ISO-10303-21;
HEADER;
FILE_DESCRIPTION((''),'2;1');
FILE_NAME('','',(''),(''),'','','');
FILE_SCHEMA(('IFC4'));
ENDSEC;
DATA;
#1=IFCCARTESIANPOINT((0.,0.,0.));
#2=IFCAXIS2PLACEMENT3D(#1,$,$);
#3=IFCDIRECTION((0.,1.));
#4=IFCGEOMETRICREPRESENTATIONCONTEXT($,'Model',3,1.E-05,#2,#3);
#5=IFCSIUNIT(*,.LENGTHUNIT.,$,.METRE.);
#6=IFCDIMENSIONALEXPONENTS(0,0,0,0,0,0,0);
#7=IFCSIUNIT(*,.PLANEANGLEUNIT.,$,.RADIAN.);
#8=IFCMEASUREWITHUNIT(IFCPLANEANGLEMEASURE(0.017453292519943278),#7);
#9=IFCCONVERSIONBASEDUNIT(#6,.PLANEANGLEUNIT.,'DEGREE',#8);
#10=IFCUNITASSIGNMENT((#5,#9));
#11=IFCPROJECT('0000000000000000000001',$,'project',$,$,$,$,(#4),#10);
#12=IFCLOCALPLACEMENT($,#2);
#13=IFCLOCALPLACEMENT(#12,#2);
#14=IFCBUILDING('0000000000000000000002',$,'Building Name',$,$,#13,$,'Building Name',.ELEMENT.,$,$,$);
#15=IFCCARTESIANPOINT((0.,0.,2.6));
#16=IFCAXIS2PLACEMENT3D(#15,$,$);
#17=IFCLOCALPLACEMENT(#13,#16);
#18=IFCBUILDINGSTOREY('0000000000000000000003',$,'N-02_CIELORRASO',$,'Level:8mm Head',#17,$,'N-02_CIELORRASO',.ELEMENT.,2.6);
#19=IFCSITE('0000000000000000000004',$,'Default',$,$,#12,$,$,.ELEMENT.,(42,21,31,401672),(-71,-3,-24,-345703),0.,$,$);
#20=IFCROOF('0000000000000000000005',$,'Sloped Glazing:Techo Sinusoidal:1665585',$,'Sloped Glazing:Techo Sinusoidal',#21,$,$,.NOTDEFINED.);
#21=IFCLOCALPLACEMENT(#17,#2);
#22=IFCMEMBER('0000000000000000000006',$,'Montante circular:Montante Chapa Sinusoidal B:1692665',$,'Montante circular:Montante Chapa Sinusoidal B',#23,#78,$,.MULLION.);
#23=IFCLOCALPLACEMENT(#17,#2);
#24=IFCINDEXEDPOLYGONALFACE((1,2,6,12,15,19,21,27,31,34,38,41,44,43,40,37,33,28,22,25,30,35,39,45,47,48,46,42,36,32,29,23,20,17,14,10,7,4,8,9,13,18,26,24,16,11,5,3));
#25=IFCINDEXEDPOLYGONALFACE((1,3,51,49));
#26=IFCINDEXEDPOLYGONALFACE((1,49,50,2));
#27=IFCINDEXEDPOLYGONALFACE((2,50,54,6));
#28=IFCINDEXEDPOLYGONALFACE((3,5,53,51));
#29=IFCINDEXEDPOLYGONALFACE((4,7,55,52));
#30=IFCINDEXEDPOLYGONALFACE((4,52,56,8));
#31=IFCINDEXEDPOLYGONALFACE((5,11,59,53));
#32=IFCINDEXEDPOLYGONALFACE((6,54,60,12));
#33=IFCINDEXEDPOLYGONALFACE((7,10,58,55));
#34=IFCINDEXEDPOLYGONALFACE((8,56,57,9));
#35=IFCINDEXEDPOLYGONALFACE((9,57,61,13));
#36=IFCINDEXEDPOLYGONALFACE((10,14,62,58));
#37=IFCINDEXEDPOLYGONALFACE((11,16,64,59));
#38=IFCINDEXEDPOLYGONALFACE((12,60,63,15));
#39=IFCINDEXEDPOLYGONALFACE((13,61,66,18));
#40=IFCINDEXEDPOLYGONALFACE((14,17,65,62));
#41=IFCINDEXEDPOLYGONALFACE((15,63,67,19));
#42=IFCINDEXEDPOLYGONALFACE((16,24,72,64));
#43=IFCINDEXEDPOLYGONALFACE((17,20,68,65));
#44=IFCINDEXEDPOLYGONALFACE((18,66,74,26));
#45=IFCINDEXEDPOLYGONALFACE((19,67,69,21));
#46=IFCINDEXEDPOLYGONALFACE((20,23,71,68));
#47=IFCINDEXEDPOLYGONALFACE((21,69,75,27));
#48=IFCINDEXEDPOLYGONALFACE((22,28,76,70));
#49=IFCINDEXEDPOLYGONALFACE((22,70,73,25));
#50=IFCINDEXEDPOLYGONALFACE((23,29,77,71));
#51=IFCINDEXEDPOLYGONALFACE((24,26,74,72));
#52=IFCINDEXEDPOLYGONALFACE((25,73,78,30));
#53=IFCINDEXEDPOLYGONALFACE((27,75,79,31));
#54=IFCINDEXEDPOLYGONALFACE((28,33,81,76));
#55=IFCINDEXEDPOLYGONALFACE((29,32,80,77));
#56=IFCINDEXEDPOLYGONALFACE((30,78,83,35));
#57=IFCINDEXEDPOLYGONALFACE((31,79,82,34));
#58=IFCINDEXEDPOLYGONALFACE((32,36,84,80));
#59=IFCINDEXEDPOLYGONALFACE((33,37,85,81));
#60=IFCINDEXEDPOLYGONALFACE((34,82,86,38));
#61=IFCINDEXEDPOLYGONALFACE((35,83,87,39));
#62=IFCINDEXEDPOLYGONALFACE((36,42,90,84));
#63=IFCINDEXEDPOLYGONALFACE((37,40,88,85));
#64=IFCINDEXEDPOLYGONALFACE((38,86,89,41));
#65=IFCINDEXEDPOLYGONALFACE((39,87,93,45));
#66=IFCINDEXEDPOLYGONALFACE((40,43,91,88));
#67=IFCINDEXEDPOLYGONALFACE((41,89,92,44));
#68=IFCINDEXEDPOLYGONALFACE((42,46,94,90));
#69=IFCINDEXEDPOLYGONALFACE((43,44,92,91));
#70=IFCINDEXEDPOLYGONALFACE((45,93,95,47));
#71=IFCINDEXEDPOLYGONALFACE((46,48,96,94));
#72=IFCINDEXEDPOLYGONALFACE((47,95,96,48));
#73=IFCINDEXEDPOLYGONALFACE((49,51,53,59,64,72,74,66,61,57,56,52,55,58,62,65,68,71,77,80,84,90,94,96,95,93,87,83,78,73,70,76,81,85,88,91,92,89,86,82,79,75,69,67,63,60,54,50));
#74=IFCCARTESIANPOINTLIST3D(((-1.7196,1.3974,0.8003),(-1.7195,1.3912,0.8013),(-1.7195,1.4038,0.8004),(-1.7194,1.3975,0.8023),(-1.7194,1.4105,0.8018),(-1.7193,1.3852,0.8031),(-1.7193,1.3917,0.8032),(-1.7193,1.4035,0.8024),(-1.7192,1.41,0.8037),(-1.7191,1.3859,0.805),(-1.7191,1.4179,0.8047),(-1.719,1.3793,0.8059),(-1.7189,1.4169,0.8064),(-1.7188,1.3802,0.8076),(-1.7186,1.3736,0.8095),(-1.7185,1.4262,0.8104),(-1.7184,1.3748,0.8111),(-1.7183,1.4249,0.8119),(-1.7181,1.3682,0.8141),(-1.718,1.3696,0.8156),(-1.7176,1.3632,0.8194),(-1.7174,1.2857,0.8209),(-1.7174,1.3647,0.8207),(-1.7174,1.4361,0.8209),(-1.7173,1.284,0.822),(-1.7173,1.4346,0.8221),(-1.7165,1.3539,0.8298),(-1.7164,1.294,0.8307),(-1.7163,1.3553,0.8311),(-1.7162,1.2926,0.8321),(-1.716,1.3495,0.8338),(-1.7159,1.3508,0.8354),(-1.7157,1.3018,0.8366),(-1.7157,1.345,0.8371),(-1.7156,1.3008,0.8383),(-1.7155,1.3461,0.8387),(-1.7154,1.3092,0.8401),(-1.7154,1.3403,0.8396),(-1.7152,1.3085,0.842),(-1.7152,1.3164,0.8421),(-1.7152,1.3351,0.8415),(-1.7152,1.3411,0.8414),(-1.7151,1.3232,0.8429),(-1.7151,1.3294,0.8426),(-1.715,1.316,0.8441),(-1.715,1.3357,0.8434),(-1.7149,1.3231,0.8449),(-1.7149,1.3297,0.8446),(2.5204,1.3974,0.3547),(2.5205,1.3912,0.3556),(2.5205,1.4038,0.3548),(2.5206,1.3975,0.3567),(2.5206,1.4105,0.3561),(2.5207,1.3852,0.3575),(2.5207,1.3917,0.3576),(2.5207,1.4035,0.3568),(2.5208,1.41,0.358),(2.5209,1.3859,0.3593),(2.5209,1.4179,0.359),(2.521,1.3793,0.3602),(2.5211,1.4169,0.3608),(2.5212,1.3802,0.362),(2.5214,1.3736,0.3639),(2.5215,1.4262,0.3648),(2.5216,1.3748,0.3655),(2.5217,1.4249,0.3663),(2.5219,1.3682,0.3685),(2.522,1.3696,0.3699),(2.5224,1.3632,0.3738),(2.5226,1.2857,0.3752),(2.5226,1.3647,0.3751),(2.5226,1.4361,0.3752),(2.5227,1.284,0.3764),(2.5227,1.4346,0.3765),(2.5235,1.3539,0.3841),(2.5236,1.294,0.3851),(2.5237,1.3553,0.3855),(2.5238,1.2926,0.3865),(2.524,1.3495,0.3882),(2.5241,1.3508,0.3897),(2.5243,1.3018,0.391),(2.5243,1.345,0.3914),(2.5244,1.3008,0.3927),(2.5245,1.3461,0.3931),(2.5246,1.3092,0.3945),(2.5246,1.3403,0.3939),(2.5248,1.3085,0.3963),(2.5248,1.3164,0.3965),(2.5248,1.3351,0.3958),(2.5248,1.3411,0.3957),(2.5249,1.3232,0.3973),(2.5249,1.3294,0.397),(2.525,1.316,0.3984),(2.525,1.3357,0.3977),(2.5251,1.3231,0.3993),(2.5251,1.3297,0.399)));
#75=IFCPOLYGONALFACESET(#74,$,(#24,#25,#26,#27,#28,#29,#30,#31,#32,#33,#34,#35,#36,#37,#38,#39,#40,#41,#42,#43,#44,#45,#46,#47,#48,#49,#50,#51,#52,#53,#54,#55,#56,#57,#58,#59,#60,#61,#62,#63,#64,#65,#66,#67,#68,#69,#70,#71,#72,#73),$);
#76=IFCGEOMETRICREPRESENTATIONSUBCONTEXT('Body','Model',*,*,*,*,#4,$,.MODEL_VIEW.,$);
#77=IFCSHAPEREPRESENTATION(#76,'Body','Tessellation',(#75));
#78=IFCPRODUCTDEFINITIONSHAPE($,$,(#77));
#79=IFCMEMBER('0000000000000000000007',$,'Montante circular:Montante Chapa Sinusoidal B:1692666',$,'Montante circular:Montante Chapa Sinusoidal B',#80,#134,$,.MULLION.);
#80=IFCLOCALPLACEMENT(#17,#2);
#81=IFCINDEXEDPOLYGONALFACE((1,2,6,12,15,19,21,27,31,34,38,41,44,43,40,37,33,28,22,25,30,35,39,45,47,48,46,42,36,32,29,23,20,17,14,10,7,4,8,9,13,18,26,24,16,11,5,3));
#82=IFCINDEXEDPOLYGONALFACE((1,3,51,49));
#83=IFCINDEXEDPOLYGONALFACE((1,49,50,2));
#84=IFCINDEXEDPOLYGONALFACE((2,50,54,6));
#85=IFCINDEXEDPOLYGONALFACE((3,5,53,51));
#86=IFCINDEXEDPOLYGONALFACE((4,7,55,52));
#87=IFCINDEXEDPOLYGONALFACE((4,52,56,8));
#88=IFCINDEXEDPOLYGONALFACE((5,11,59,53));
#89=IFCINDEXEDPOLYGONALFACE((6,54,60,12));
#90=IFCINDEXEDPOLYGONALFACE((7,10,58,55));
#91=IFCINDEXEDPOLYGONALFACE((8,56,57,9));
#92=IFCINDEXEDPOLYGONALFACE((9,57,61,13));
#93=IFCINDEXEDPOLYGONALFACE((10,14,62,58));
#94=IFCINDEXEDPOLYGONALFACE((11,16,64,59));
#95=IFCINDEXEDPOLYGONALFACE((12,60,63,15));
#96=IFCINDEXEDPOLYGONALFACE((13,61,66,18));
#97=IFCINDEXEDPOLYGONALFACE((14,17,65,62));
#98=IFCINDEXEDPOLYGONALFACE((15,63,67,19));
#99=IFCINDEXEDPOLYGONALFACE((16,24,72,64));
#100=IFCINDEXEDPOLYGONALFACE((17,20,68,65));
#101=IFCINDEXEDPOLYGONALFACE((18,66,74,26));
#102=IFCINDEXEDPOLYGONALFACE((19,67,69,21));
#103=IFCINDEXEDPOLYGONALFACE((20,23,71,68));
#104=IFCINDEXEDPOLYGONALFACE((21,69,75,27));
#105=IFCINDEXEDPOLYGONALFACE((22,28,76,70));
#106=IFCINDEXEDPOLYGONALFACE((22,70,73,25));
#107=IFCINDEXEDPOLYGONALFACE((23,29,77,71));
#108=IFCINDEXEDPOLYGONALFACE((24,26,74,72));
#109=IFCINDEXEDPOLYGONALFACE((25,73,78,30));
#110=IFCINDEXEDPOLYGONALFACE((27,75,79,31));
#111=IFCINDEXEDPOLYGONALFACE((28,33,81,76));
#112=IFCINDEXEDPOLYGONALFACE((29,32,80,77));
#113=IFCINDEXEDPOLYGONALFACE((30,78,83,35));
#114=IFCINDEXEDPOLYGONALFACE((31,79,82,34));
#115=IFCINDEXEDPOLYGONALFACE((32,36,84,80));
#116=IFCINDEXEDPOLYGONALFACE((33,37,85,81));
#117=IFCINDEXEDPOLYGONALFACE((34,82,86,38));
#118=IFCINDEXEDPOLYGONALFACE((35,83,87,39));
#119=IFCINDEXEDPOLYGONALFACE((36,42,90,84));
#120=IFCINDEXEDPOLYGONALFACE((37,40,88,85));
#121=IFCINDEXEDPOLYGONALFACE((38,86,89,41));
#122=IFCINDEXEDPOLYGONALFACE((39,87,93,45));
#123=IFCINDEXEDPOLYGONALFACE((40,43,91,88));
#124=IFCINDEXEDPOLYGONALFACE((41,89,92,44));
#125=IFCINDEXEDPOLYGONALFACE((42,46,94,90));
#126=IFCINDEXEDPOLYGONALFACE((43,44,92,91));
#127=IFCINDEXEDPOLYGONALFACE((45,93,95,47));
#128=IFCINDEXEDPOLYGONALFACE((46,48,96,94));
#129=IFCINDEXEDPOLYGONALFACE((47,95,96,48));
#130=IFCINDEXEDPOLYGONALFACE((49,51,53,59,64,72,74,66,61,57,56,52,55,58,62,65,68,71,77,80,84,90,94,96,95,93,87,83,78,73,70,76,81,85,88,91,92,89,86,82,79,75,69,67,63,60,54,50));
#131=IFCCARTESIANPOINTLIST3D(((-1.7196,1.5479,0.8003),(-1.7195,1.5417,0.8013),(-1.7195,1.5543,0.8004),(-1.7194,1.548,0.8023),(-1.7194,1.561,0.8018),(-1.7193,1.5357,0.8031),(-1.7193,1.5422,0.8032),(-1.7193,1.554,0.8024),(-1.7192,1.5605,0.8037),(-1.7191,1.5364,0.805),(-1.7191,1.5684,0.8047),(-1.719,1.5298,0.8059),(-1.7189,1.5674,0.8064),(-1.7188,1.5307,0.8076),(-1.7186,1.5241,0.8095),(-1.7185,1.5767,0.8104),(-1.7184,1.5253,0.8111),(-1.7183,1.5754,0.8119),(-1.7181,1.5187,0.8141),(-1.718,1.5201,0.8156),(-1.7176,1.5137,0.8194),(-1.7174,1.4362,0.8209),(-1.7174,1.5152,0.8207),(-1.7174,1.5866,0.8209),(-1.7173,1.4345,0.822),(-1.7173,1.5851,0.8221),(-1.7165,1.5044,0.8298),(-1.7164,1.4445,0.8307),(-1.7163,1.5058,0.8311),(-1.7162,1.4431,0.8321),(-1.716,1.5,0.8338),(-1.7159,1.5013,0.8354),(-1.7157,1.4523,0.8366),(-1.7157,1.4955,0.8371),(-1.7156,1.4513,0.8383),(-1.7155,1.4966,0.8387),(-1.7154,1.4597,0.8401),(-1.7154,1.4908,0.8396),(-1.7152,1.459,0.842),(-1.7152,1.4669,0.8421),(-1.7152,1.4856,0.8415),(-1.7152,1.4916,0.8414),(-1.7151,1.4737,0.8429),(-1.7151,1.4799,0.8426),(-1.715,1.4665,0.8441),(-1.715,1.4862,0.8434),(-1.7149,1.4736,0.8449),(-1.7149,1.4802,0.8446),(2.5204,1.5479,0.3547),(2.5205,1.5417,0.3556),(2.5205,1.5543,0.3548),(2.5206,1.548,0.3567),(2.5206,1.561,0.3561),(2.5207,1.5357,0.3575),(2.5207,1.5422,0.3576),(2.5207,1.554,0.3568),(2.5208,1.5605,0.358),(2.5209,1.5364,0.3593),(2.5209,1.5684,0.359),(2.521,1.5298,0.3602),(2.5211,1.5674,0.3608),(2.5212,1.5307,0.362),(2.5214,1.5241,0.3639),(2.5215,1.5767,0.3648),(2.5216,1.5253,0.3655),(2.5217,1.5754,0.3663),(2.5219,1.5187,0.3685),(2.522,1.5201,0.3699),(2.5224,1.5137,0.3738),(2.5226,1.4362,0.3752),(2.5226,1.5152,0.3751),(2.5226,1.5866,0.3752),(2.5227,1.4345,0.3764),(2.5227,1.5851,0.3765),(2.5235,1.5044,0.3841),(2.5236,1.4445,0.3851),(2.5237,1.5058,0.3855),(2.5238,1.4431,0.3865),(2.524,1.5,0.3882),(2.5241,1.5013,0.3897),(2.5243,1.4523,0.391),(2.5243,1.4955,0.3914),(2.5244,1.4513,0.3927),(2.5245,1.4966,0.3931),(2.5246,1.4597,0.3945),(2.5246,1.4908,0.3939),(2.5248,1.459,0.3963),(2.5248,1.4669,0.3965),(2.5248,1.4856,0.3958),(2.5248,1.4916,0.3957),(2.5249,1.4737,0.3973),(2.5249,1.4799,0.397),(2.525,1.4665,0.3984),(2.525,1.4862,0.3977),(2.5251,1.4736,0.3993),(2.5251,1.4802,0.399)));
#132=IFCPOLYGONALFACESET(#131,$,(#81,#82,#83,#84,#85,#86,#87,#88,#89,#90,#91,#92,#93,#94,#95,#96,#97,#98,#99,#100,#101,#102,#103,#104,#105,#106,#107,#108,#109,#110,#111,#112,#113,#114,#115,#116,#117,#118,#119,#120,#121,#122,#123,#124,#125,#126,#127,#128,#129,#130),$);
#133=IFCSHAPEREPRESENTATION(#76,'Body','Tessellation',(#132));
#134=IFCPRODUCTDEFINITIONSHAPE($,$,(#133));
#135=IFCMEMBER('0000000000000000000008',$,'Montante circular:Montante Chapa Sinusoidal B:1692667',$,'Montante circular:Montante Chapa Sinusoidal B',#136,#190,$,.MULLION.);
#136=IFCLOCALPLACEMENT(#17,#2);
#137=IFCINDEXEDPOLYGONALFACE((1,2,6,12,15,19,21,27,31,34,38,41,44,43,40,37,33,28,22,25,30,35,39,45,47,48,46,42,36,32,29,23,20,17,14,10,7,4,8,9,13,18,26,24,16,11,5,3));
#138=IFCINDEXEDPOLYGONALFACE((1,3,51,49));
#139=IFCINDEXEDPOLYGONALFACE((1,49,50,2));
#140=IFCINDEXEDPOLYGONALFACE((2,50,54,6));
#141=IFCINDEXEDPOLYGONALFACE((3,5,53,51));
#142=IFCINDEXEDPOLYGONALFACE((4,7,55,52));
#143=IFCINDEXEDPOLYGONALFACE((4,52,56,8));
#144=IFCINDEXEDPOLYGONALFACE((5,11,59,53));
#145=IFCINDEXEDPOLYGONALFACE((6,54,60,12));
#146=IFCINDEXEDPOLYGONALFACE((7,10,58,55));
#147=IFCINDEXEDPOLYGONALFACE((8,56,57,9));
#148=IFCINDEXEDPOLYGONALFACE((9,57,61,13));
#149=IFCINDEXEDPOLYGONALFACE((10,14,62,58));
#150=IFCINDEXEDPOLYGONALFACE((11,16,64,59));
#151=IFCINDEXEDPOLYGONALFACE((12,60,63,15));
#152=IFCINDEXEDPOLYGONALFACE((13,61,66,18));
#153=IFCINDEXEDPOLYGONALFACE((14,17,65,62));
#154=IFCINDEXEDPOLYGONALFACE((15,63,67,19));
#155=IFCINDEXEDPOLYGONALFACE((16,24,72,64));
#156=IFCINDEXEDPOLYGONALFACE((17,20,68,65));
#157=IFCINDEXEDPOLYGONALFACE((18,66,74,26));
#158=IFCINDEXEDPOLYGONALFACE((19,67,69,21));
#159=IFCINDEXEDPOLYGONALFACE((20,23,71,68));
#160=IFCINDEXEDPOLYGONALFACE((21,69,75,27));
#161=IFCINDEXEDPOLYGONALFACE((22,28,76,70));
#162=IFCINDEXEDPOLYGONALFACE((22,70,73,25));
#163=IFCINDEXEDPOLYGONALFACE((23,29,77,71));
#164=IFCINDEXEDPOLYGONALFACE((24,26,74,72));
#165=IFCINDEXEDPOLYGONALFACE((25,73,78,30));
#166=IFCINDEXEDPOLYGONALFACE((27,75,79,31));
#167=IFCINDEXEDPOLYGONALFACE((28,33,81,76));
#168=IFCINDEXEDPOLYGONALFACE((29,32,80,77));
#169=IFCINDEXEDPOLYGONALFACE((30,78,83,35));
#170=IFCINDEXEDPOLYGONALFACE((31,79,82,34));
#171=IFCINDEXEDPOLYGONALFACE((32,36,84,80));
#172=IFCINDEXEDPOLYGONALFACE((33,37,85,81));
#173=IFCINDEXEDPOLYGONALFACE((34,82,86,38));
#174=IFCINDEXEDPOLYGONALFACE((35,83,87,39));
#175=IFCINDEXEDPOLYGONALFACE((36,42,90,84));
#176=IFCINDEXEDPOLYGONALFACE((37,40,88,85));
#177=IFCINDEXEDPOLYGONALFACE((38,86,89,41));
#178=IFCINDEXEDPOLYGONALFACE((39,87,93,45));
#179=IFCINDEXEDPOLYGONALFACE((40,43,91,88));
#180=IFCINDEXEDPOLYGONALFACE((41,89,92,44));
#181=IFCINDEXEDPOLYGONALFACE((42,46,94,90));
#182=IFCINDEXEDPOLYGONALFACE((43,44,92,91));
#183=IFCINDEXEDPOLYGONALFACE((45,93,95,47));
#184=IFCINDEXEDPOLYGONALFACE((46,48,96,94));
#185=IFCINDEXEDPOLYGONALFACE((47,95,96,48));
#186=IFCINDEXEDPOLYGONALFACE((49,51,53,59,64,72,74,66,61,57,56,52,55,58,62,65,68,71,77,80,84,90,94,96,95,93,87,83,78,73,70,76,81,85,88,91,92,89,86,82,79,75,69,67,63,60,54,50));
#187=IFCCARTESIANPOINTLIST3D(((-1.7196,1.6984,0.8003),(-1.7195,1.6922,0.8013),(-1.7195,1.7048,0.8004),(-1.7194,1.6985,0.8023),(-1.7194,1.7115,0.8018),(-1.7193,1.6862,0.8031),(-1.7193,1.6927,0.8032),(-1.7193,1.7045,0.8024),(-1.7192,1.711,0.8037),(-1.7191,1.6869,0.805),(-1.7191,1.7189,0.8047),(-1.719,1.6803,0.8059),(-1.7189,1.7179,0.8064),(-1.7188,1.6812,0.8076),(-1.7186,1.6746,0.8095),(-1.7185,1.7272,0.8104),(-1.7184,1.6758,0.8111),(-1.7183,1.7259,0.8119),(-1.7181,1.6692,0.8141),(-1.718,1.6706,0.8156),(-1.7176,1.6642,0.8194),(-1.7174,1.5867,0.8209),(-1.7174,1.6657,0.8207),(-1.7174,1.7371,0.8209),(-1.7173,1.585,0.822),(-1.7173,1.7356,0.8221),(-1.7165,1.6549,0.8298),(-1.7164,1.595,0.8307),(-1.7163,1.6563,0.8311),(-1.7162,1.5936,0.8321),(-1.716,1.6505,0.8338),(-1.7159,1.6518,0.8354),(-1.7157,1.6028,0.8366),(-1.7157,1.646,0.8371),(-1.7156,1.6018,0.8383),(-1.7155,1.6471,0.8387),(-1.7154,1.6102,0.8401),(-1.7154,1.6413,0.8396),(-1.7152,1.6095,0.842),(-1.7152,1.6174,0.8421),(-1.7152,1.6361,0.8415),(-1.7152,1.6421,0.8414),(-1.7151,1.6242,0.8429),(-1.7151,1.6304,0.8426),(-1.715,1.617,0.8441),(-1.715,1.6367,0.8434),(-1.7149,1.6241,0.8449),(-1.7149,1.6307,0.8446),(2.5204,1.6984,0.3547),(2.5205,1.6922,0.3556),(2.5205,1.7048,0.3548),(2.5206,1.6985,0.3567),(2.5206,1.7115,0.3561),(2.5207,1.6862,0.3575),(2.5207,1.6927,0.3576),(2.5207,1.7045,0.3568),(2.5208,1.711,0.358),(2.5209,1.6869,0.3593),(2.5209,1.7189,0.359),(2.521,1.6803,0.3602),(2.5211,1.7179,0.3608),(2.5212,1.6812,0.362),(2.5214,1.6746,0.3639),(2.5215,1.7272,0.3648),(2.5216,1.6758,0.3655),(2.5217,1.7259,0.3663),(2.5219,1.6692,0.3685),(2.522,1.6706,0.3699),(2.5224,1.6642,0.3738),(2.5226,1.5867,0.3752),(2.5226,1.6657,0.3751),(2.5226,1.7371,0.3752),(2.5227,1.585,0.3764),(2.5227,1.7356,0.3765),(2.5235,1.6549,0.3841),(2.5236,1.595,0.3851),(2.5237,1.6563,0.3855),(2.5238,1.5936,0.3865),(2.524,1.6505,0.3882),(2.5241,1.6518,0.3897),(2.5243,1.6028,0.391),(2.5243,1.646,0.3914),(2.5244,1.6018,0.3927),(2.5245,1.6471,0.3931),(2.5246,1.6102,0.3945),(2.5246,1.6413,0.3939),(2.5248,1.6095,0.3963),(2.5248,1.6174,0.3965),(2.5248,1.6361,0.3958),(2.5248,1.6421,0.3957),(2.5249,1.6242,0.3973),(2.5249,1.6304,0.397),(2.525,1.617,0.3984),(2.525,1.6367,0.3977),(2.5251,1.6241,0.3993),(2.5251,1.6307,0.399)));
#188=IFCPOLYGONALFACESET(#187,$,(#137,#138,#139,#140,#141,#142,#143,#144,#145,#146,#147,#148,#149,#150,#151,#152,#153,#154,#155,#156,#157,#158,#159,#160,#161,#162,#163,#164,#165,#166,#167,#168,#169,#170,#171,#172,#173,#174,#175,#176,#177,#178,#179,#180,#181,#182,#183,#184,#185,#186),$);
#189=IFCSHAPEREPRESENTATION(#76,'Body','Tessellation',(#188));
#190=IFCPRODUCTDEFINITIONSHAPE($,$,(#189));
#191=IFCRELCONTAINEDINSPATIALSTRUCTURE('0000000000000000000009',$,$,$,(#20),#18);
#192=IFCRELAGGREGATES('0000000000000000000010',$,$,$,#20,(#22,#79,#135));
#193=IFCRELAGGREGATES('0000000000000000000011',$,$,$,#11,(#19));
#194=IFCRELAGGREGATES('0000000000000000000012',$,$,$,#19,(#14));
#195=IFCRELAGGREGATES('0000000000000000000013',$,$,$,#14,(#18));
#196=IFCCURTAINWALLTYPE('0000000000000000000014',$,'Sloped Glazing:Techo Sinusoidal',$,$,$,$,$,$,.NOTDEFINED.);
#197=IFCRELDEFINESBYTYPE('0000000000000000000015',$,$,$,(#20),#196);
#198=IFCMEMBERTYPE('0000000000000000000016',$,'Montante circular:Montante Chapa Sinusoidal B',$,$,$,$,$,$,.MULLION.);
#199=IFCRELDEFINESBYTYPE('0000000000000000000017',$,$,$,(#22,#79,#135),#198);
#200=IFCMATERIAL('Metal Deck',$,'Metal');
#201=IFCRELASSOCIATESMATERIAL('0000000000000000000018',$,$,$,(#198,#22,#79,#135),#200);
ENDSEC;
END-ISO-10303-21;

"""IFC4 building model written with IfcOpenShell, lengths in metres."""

from ifc_helpers import new_model, entity, si_unit, converted_unit, direction, frame, origin, place, context, subcontext, project, spatial, indexed_curve, outline, extrude, source, transform, mapped, material, type_object, type_shapes, element, aggregate, save


model = new_model("IFC4")

# Units and contexts
model_context = context("Model", 3, precision=1e-05, world=origin(), true_north=direction((0.0, 1.0)))
body_context = subcontext(model_context, "Body", "Model", "MODEL_VIEW")
ifc_project = project(units=[si_unit("LENGTHUNIT", "METRE"), converted_unit("PLANEANGLEUNIT", "DEGREE", entity("IfcPlaneAngleMeasure", 0.017453292519943278), si_unit("PLANEANGLEUNIT", "RADIAN"), dimensions=[0, 0, 0, 0, 0, 0, 0])], contexts=[model_context])

# Site, building, storey
site_placement = place(None, origin())
site = spatial("IfcSite", under=ifc_project, at=site_placement, Name="Default", CompositionType="ELEMENT", RefLatitude=(42, 21, 31, 401672), RefLongitude=(-71, -3, -24, -345703), RefElevation=0.0)
building_placement = place(site_placement, origin())
building = spatial("IfcBuilding", under=site, at=building_placement, Name="Building Name", LongName="Building Name", CompositionType="ELEMENT")
storey_placement = place(building_placement, frame((0.0, 0.0, 2.6)))
storey = spatial("IfcBuildingStorey", under=building, at=storey_placement, Name="N-02_CIELORRASO", ObjectType="Level:8mm Head", LongName="N-02_CIELORRASO", CompositionType="ELEMENT", Elevation=2.6)

# Roof, members
curtain_wall_type = type_object("IfcCurtainWallType", Name="Sloped Glazing:Techo Sinusoidal", PredefinedType="NOTDEFINED")
roof_placement = place(storey_placement, frame((0.0, 0.0, -2.6)))
roof = element("IfcRoof", 1, at=roof_placement, inside=storey, type_object=curtain_wall_type, Name="Sloped Glazing:Techo Sinusoidal:1665585", ObjectType="Sloped Glazing:Techo Sinusoidal", PredefinedType="NOTDEFINED")
ifc_material = material(Name="Metal Deck", Category="Metal")
member_type = type_object("IfcMemberType", Name="Montante circular:Montante Chapa Sinusoidal B", PredefinedType="MULLION", material=ifc_material)
shared_shape = source(origin(), body_context, "Body", "SweptSolid", [
    extrude(outline(indexed_curve([(0.0595, -0.0443), (0.0615, -0.0443), (0.0603, -0.031), (0.0572, -0.0213), (0.053, -0.0138), (0.0481, -0.0078), (0.0427, -0.003), (0.0372, 0.0005), (0.0315, 0.0029), (0.0259, 0.0044), (0.0203, 0.0051), (0.0146, 0.005), (0.0084, 0.0041), (-0.0053, 0.0009), (-0.0123, -0.0005), (-0.0191, -0.0012), (-0.0256, -0.001), (-0.0317, 0.0001), (-0.0375, 0.0019), (-0.0428, 0.0046), (-0.0477, 0.0081), (-0.0522, 0.0128), (-0.0563, 0.0191), (-0.0597, 0.0282), (-0.0617, 0.0421), (-0.0637, 0.042), (-0.0616, 0.0277), (-0.0581, 0.0182), (-0.0537, 0.0116), (-0.049, 0.0066), (-0.0438, 0.0028), (-0.0382, 0.0001), (-0.0322, -0.0019), (-0.0258, -0.003), (-0.019, -0.0032), (-0.012, -0.0025), (-0.0048, -0.0011), (0.0088, 0.0021), (0.0147, 0.003), (0.0202, 0.0031), (0.0255, 0.0024), (0.0309, 0.001), (0.0362, -0.0013), (0.0415, -0.0046), (0.0466, -0.0092), (0.0513, -0.0149), (0.0554, -0.0221), (0.0584, -0.0314), (0.0595, -0.0443)], self_intersect=False)), frame((-0.007, 0.0228, -4.2634), z_axis=(0.0, 0.0, 1.0), x_axis=(-0.819152, -0.573576, 0.0)), (0.0, 0.0, 1.0), 4.2634),
])
type_shapes(member_type, [shared_shape])
member_1_placement = place(roof_placement, frame((-1.7148, 1.3669, 3.4456), z_axis=(-0.994522, 0.0, 0.104528), x_axis=(0.0, 1.0, 0.0)))
member_1 = element("IfcMember", 2, at=member_1_placement, type_object=member_type, material=ifc_material, Name="Montante circular:Montante Chapa Sinusoidal B:1692665", ObjectType="Montante circular:Montante Chapa Sinusoidal B", PredefinedType="MULLION", context=body_context, shape_type="MappedRepresentation", body=[
    mapped(shared_shape, transform((0.0, 0.0, 0.0), scale=1.0)),
])
member_2_placement = place(roof_placement, frame((-1.7148, 1.5174, 3.4456), z_axis=(-0.994522, 0.0, 0.104528), x_axis=(0.0, 1.0, 0.0)))
member_2 = element("IfcMember", 3, at=member_2_placement, type_object=member_type, material=ifc_material, Name="Montante circular:Montante Chapa Sinusoidal B:1692666", ObjectType="Montante circular:Montante Chapa Sinusoidal B", PredefinedType="MULLION", context=body_context, shape_type="MappedRepresentation", body=[
    mapped(shared_shape, transform((0.0, 0.0, 0.0), scale=1.0)),
])
member_3_placement = place(roof_placement, frame((-1.7148, 1.6679, 3.4456), z_axis=(-0.994522, 0.0, 0.104528), x_axis=(0.0, 1.0, 0.0)))
member_3 = element("IfcMember", 4, at=member_3_placement, type_object=member_type, material=ifc_material, Name="Montante circular:Montante Chapa Sinusoidal B:1692667", ObjectType="Montante circular:Montante Chapa Sinusoidal B", PredefinedType="MULLION", context=body_context, shape_type="MappedRepresentation", body=[
    mapped(shared_shape, transform((0.0, 0.0, 0.0), scale=1.0)),
])
aggregate(roof, [member_1, member_2, member_3])

save(model, "model.ifc")
